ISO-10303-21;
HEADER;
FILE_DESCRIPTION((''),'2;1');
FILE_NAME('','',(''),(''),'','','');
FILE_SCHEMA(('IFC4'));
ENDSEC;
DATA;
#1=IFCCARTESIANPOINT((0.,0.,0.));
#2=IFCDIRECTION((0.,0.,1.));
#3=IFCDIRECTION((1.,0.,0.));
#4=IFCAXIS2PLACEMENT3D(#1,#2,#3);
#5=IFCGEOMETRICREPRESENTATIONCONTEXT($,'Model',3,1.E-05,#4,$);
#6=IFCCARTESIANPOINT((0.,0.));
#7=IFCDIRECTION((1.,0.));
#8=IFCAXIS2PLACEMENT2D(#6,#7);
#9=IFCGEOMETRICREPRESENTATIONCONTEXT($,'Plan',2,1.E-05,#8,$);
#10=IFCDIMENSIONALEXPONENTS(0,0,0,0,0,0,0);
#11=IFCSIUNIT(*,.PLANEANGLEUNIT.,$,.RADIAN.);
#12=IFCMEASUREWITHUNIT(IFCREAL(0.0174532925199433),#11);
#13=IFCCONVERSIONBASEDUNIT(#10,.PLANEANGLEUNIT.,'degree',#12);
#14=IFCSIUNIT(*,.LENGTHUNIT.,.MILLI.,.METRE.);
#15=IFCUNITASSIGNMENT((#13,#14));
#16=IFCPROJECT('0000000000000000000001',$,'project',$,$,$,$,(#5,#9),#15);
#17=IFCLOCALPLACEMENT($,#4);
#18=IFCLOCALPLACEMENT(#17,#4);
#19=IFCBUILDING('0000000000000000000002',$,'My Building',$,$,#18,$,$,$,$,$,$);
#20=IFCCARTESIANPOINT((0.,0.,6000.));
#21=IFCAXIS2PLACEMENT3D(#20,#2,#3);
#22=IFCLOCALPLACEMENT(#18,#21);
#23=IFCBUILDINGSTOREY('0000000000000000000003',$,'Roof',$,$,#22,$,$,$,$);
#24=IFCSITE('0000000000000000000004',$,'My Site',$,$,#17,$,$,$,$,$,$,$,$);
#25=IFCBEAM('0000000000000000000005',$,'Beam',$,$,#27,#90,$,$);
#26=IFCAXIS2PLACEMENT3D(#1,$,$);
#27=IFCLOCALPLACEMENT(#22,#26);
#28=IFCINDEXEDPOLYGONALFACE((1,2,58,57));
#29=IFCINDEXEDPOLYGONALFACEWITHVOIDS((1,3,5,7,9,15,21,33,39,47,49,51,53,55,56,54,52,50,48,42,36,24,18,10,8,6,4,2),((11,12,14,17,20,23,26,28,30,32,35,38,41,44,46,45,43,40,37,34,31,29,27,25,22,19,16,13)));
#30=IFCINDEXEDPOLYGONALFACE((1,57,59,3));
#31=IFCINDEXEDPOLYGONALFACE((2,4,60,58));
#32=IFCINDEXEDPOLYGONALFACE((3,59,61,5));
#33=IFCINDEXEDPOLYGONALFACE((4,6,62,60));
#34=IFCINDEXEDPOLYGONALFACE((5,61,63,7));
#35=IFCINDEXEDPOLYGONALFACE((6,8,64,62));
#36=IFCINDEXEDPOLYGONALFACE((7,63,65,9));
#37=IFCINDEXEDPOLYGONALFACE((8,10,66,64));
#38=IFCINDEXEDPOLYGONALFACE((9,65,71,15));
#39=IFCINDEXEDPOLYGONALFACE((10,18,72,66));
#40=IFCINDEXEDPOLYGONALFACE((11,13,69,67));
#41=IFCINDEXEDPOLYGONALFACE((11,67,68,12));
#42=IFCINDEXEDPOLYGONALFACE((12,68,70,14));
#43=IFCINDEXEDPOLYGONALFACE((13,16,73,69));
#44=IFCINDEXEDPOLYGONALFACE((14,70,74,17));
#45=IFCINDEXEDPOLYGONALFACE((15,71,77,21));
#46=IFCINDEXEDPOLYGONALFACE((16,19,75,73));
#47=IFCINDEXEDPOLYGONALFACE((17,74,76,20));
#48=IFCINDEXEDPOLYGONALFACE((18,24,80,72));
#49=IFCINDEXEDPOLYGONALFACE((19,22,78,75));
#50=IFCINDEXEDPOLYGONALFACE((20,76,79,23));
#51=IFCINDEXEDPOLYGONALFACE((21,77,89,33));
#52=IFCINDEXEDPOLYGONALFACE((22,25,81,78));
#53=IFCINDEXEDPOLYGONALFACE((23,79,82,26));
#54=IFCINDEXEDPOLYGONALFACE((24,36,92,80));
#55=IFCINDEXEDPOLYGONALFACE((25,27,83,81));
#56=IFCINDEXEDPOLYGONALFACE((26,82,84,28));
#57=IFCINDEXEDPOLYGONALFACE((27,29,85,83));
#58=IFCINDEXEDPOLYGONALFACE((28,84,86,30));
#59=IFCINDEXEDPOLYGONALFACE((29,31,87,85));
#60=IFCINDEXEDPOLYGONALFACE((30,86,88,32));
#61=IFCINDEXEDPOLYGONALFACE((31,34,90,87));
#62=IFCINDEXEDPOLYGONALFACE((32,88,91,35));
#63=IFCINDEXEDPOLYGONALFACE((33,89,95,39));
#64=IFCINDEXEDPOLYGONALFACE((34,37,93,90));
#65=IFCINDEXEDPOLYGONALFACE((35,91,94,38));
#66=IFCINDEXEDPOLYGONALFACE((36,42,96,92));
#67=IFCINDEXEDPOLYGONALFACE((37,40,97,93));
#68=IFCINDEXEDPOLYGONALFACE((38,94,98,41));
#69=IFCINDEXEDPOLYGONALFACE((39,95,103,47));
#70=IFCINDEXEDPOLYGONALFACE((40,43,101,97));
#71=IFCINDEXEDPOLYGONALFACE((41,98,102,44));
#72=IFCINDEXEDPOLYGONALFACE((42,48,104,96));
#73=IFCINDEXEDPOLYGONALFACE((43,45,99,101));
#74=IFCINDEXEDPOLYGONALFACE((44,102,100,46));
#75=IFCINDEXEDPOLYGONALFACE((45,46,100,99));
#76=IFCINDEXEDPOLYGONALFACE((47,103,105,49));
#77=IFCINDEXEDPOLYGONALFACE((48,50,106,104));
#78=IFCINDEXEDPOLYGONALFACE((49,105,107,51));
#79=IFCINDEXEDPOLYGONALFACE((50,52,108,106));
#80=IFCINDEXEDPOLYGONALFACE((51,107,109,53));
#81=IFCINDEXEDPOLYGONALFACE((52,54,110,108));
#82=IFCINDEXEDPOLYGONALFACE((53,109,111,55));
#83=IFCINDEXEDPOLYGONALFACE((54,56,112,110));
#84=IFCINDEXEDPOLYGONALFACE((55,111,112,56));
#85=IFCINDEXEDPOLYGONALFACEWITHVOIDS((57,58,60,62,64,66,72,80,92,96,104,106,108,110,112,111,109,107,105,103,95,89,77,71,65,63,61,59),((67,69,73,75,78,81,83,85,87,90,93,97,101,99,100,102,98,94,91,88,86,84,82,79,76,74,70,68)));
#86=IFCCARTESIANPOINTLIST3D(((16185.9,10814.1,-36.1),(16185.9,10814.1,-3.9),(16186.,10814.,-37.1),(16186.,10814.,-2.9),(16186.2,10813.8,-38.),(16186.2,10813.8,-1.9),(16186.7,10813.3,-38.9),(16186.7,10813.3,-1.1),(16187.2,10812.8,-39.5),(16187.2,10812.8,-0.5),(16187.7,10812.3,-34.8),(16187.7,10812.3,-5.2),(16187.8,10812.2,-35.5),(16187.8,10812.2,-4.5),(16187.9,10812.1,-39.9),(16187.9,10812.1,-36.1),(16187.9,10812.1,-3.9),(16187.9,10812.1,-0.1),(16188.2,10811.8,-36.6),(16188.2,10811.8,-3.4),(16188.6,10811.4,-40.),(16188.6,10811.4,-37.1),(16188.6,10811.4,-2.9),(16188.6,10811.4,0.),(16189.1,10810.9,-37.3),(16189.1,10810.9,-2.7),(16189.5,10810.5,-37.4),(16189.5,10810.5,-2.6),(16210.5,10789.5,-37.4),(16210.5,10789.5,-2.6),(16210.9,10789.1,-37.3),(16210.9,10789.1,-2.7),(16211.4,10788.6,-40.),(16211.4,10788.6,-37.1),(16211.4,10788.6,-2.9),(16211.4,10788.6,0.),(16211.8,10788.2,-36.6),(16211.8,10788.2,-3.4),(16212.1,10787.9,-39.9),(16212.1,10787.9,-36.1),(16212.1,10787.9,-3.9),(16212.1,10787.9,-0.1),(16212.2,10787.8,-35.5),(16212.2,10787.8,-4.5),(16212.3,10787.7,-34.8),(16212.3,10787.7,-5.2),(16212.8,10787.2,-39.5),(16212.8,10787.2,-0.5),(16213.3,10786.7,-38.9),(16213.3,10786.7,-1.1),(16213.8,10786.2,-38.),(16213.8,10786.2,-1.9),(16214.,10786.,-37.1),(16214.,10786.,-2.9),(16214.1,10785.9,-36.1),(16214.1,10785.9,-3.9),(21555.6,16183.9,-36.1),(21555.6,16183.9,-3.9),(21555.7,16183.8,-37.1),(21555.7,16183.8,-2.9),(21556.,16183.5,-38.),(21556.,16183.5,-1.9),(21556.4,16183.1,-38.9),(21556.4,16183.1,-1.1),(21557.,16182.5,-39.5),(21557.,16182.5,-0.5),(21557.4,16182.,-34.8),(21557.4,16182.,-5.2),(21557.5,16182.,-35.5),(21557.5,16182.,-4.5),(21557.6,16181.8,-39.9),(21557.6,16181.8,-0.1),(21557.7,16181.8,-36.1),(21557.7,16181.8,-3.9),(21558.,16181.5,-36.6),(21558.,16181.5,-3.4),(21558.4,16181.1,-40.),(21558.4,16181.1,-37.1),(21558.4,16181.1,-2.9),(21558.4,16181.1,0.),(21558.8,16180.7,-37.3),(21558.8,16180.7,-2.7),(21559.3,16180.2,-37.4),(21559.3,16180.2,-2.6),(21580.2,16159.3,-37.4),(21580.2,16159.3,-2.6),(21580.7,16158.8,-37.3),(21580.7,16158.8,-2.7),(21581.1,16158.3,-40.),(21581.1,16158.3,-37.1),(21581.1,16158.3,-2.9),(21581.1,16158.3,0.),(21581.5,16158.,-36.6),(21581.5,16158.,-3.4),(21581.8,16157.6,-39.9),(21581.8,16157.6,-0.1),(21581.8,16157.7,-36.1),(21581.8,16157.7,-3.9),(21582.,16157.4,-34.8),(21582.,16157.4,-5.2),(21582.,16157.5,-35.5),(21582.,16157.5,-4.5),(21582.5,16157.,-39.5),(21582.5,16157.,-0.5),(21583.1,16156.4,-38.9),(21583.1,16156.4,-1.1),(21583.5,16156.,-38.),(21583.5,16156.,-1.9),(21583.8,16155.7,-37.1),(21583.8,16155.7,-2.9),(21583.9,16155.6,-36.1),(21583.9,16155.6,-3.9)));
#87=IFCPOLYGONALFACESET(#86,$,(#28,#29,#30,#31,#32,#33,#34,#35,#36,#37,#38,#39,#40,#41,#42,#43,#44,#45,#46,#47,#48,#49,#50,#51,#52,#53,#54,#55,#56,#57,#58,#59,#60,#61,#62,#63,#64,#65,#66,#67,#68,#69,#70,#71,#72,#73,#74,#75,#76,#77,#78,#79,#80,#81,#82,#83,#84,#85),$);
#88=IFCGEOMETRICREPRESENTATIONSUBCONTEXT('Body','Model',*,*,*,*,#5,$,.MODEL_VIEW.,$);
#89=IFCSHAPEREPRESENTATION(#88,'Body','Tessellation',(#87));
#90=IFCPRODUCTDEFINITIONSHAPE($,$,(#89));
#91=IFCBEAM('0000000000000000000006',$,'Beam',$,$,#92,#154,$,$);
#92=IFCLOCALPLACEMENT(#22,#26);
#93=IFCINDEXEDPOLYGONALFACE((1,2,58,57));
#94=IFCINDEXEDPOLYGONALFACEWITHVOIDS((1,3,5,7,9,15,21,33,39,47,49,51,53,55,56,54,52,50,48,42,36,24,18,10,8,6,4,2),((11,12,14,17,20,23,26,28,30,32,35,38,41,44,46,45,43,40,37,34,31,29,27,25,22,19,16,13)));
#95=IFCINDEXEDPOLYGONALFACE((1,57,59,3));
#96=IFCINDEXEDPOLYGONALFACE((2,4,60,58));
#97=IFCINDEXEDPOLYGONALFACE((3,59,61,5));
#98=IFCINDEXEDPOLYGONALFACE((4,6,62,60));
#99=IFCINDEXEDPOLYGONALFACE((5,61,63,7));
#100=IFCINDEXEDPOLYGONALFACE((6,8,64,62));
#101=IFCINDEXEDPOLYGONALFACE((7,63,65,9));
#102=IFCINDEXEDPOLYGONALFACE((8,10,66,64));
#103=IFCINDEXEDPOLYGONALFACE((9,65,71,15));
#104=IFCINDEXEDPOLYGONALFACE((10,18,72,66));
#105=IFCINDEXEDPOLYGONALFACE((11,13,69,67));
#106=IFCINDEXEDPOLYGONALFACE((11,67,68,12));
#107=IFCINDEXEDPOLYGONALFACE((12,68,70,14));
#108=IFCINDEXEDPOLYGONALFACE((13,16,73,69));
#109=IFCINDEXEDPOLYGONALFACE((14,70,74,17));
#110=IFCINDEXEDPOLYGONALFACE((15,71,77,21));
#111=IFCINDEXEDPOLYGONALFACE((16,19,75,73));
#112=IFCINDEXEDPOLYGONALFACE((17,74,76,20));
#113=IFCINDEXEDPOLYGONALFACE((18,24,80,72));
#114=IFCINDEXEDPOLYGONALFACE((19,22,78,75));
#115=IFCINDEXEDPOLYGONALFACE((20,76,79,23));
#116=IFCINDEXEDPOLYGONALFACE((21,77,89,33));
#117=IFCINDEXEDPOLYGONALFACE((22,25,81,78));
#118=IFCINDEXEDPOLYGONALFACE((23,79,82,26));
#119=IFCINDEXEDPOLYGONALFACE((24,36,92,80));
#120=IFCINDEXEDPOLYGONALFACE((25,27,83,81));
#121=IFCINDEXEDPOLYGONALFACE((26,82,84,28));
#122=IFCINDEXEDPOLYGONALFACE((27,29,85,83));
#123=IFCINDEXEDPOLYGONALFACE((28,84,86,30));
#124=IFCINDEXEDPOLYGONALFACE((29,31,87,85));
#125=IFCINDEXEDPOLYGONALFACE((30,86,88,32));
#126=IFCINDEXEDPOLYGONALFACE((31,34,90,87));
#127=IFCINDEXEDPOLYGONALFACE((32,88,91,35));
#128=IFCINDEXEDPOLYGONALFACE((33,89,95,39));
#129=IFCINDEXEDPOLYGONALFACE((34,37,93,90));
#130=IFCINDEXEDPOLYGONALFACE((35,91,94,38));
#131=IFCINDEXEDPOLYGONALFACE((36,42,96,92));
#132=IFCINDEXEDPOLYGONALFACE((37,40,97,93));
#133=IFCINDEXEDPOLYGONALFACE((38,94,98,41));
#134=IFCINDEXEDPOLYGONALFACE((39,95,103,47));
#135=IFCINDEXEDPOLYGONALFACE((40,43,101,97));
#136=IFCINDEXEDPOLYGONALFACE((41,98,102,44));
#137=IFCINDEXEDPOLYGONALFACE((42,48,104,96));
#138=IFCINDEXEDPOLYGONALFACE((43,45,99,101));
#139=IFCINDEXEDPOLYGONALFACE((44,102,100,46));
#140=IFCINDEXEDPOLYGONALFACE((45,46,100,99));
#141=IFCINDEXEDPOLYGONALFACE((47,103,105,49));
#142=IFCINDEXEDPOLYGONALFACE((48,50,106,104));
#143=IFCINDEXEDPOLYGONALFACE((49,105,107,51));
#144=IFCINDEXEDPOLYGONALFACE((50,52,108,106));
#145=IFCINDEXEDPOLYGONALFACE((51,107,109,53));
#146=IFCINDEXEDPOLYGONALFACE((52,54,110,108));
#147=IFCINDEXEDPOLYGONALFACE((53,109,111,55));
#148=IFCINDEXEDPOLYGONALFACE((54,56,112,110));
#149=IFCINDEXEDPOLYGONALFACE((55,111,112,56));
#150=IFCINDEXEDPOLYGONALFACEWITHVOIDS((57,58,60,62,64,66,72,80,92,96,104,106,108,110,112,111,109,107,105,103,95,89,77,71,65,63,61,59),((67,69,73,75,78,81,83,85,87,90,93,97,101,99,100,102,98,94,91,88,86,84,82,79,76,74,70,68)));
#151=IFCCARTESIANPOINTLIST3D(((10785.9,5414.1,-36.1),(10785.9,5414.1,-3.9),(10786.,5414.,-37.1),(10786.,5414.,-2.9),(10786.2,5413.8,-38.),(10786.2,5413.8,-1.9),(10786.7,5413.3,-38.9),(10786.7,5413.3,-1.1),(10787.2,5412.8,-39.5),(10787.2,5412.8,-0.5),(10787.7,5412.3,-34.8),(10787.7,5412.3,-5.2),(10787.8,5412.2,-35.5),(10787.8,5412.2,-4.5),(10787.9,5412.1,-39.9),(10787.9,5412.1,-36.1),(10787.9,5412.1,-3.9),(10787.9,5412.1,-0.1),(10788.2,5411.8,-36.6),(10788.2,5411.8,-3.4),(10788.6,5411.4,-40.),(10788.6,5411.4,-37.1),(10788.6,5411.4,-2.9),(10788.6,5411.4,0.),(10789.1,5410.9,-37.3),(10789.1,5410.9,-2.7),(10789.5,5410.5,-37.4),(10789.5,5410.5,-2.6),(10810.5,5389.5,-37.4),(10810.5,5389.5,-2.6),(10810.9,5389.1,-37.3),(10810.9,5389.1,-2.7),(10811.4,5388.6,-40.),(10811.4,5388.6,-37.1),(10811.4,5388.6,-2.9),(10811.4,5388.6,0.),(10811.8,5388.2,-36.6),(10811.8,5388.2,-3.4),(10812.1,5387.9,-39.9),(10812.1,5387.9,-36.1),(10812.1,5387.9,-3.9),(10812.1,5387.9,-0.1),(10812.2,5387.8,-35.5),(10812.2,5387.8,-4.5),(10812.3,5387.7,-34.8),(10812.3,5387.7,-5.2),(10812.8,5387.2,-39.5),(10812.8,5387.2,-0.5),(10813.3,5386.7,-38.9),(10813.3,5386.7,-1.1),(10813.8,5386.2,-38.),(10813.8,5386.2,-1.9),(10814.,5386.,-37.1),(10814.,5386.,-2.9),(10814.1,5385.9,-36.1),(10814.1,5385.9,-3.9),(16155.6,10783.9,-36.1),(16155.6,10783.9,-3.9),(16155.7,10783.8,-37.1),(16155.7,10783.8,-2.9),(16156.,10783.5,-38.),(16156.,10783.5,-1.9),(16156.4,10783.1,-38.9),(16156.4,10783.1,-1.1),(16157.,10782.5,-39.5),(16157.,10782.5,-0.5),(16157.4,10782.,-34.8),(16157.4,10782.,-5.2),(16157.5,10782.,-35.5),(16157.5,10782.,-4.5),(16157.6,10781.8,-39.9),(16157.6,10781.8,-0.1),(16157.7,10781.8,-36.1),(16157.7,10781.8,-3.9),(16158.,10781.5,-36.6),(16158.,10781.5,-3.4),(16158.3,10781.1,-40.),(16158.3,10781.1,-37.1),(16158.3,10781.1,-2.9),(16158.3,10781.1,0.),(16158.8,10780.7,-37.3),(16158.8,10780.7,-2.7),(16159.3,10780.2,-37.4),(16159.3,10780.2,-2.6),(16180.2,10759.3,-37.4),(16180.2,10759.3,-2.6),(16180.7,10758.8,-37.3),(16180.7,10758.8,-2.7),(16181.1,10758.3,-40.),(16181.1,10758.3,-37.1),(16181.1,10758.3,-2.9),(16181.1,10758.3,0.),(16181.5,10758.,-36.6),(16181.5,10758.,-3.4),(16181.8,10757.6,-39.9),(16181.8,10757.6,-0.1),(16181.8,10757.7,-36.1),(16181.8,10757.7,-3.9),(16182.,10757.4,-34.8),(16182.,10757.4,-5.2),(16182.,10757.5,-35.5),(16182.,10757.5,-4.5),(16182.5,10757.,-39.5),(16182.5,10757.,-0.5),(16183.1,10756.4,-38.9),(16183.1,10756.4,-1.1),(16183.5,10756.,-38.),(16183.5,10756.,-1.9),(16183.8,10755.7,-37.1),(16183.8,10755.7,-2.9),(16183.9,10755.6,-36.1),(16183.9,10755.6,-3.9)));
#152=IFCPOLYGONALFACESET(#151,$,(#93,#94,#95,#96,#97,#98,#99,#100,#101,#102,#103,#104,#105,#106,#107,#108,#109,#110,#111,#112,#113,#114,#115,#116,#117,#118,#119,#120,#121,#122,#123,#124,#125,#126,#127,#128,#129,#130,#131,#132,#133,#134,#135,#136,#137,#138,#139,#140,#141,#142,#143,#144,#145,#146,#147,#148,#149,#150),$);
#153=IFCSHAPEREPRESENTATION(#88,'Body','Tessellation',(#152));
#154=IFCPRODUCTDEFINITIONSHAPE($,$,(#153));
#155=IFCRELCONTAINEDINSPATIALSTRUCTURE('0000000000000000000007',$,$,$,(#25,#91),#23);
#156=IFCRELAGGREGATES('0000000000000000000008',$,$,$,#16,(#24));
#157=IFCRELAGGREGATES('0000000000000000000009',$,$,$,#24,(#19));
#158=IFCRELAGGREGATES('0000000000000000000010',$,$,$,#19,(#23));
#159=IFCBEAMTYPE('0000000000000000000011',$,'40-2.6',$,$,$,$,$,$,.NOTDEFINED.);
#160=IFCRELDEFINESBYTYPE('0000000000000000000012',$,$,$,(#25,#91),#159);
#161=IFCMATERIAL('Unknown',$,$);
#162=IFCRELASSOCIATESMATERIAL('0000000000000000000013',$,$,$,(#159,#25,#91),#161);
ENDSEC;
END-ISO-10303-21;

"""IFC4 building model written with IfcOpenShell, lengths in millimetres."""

from ifc_helpers import new_model, entity, si_unit, converted_unit, frame, origin_with_axes, origin_2d_with_axis, place, context, subcontext, project, spatial, hollow_rectangle, extrude, material, material_profile, profile_set, profile_usage, type_object, element, save


model = new_model("IFC4")

# Units and contexts
model_context = context("Model", 3, precision=1e-05, world=origin_with_axes())
plan_context = context("Plan", 2, precision=1e-05, world=origin_2d_with_axis())
body_context = subcontext(model_context, "Body", "Model", "MODEL_VIEW")
ifc_project = project(units=[converted_unit("PLANEANGLEUNIT", "degree", entity("IfcReal", 0.0174532925199433), si_unit("PLANEANGLEUNIT", "RADIAN"), dimensions=[0, 0, 0, 0, 0, 0, 0]), si_unit("LENGTHUNIT", "METRE", prefix="MILLI")], contexts=[model_context, plan_context])

# Site, building, storey
site_placement = place(None, origin_with_axes())
site = spatial("IfcSite", under=ifc_project, at=site_placement, Name="My Site")
building_placement = place(site_placement, origin_with_axes())
building = spatial("IfcBuilding", under=site, at=building_placement, Name="My Building")
storey_placement = place(building_placement, frame((0.0, 0.0, 6000.0), z_axis=(0.0, 0.0, 1.0), x_axis=(1.0, 0.0, 0.0)))
storey = spatial("IfcBuildingStorey", under=building, at=storey_placement, Name="Roof")

# Beams
ifc_material = material(Name="Unknown")
ifc_material_profile_1 = material_profile(ifc_material, hollow_rectangle(XDim=40.0, YDim=40.0, WallThickness=2.6, InnerFilletRadius=2.6, OuterFilletRadius=3.9))
ifc_profile_set_1 = profile_set([ifc_material_profile_1])
ifc_profile_usage_1 = profile_usage(ifc_profile_set_1, cardinal=8)
beam_type_1 = type_object("IfcBeamType", Name="40-2.6", PredefinedType="NOTDEFINED", material=ifc_profile_set_1)
beam_1_placement = place(storey_placement, frame((16200.0, 10800.0, 0.0), z_axis=(0.707107, 0.707107, 0.0), x_axis=(-0.707107, 0.707107, 0.0)))
element("IfcBeam", 1, at=beam_1_placement, inside=storey, type_object=beam_type_1, material=ifc_profile_usage_1, Name="Beam", context=body_context, shape_type="SweptSolid", body=[
    extrude(hollow_rectangle(XDim=40.0, YDim=40.0, WallThickness=2.6, InnerFilletRadius=2.6, OuterFilletRadius=3.9), frame((0.0, -20.0, 0.0), z_axis=(0.0, 0.0, 1.0), x_axis=(1.0, 0.0, 0.0)), (0.0, 0.0, 1.0), 7594.0),
])
ifc_profile_usage_2 = profile_usage(ifc_profile_set_1, cardinal=8)
beam_2_placement = place(storey_placement, frame((10800.0, 5400.0, 0.0), z_axis=(0.707107, 0.707107, 0.0), x_axis=(-0.707107, 0.707107, 0.0)))
element("IfcBeam", 2, at=beam_2_placement, inside=storey, type_object=beam_type_1, material=ifc_profile_usage_2, Name="Beam", context=body_context, shape_type="SweptSolid", body=[
    extrude(hollow_rectangle(XDim=40.0, YDim=40.0, WallThickness=2.6, InnerFilletRadius=2.6, OuterFilletRadius=3.9), frame((0.0, -20.0, 0.0), z_axis=(0.0, 0.0, 1.0), x_axis=(1.0, 0.0, 0.0)), (0.0, 0.0, 1.0), 7594.0),
])

save(model, "model.ifc")
